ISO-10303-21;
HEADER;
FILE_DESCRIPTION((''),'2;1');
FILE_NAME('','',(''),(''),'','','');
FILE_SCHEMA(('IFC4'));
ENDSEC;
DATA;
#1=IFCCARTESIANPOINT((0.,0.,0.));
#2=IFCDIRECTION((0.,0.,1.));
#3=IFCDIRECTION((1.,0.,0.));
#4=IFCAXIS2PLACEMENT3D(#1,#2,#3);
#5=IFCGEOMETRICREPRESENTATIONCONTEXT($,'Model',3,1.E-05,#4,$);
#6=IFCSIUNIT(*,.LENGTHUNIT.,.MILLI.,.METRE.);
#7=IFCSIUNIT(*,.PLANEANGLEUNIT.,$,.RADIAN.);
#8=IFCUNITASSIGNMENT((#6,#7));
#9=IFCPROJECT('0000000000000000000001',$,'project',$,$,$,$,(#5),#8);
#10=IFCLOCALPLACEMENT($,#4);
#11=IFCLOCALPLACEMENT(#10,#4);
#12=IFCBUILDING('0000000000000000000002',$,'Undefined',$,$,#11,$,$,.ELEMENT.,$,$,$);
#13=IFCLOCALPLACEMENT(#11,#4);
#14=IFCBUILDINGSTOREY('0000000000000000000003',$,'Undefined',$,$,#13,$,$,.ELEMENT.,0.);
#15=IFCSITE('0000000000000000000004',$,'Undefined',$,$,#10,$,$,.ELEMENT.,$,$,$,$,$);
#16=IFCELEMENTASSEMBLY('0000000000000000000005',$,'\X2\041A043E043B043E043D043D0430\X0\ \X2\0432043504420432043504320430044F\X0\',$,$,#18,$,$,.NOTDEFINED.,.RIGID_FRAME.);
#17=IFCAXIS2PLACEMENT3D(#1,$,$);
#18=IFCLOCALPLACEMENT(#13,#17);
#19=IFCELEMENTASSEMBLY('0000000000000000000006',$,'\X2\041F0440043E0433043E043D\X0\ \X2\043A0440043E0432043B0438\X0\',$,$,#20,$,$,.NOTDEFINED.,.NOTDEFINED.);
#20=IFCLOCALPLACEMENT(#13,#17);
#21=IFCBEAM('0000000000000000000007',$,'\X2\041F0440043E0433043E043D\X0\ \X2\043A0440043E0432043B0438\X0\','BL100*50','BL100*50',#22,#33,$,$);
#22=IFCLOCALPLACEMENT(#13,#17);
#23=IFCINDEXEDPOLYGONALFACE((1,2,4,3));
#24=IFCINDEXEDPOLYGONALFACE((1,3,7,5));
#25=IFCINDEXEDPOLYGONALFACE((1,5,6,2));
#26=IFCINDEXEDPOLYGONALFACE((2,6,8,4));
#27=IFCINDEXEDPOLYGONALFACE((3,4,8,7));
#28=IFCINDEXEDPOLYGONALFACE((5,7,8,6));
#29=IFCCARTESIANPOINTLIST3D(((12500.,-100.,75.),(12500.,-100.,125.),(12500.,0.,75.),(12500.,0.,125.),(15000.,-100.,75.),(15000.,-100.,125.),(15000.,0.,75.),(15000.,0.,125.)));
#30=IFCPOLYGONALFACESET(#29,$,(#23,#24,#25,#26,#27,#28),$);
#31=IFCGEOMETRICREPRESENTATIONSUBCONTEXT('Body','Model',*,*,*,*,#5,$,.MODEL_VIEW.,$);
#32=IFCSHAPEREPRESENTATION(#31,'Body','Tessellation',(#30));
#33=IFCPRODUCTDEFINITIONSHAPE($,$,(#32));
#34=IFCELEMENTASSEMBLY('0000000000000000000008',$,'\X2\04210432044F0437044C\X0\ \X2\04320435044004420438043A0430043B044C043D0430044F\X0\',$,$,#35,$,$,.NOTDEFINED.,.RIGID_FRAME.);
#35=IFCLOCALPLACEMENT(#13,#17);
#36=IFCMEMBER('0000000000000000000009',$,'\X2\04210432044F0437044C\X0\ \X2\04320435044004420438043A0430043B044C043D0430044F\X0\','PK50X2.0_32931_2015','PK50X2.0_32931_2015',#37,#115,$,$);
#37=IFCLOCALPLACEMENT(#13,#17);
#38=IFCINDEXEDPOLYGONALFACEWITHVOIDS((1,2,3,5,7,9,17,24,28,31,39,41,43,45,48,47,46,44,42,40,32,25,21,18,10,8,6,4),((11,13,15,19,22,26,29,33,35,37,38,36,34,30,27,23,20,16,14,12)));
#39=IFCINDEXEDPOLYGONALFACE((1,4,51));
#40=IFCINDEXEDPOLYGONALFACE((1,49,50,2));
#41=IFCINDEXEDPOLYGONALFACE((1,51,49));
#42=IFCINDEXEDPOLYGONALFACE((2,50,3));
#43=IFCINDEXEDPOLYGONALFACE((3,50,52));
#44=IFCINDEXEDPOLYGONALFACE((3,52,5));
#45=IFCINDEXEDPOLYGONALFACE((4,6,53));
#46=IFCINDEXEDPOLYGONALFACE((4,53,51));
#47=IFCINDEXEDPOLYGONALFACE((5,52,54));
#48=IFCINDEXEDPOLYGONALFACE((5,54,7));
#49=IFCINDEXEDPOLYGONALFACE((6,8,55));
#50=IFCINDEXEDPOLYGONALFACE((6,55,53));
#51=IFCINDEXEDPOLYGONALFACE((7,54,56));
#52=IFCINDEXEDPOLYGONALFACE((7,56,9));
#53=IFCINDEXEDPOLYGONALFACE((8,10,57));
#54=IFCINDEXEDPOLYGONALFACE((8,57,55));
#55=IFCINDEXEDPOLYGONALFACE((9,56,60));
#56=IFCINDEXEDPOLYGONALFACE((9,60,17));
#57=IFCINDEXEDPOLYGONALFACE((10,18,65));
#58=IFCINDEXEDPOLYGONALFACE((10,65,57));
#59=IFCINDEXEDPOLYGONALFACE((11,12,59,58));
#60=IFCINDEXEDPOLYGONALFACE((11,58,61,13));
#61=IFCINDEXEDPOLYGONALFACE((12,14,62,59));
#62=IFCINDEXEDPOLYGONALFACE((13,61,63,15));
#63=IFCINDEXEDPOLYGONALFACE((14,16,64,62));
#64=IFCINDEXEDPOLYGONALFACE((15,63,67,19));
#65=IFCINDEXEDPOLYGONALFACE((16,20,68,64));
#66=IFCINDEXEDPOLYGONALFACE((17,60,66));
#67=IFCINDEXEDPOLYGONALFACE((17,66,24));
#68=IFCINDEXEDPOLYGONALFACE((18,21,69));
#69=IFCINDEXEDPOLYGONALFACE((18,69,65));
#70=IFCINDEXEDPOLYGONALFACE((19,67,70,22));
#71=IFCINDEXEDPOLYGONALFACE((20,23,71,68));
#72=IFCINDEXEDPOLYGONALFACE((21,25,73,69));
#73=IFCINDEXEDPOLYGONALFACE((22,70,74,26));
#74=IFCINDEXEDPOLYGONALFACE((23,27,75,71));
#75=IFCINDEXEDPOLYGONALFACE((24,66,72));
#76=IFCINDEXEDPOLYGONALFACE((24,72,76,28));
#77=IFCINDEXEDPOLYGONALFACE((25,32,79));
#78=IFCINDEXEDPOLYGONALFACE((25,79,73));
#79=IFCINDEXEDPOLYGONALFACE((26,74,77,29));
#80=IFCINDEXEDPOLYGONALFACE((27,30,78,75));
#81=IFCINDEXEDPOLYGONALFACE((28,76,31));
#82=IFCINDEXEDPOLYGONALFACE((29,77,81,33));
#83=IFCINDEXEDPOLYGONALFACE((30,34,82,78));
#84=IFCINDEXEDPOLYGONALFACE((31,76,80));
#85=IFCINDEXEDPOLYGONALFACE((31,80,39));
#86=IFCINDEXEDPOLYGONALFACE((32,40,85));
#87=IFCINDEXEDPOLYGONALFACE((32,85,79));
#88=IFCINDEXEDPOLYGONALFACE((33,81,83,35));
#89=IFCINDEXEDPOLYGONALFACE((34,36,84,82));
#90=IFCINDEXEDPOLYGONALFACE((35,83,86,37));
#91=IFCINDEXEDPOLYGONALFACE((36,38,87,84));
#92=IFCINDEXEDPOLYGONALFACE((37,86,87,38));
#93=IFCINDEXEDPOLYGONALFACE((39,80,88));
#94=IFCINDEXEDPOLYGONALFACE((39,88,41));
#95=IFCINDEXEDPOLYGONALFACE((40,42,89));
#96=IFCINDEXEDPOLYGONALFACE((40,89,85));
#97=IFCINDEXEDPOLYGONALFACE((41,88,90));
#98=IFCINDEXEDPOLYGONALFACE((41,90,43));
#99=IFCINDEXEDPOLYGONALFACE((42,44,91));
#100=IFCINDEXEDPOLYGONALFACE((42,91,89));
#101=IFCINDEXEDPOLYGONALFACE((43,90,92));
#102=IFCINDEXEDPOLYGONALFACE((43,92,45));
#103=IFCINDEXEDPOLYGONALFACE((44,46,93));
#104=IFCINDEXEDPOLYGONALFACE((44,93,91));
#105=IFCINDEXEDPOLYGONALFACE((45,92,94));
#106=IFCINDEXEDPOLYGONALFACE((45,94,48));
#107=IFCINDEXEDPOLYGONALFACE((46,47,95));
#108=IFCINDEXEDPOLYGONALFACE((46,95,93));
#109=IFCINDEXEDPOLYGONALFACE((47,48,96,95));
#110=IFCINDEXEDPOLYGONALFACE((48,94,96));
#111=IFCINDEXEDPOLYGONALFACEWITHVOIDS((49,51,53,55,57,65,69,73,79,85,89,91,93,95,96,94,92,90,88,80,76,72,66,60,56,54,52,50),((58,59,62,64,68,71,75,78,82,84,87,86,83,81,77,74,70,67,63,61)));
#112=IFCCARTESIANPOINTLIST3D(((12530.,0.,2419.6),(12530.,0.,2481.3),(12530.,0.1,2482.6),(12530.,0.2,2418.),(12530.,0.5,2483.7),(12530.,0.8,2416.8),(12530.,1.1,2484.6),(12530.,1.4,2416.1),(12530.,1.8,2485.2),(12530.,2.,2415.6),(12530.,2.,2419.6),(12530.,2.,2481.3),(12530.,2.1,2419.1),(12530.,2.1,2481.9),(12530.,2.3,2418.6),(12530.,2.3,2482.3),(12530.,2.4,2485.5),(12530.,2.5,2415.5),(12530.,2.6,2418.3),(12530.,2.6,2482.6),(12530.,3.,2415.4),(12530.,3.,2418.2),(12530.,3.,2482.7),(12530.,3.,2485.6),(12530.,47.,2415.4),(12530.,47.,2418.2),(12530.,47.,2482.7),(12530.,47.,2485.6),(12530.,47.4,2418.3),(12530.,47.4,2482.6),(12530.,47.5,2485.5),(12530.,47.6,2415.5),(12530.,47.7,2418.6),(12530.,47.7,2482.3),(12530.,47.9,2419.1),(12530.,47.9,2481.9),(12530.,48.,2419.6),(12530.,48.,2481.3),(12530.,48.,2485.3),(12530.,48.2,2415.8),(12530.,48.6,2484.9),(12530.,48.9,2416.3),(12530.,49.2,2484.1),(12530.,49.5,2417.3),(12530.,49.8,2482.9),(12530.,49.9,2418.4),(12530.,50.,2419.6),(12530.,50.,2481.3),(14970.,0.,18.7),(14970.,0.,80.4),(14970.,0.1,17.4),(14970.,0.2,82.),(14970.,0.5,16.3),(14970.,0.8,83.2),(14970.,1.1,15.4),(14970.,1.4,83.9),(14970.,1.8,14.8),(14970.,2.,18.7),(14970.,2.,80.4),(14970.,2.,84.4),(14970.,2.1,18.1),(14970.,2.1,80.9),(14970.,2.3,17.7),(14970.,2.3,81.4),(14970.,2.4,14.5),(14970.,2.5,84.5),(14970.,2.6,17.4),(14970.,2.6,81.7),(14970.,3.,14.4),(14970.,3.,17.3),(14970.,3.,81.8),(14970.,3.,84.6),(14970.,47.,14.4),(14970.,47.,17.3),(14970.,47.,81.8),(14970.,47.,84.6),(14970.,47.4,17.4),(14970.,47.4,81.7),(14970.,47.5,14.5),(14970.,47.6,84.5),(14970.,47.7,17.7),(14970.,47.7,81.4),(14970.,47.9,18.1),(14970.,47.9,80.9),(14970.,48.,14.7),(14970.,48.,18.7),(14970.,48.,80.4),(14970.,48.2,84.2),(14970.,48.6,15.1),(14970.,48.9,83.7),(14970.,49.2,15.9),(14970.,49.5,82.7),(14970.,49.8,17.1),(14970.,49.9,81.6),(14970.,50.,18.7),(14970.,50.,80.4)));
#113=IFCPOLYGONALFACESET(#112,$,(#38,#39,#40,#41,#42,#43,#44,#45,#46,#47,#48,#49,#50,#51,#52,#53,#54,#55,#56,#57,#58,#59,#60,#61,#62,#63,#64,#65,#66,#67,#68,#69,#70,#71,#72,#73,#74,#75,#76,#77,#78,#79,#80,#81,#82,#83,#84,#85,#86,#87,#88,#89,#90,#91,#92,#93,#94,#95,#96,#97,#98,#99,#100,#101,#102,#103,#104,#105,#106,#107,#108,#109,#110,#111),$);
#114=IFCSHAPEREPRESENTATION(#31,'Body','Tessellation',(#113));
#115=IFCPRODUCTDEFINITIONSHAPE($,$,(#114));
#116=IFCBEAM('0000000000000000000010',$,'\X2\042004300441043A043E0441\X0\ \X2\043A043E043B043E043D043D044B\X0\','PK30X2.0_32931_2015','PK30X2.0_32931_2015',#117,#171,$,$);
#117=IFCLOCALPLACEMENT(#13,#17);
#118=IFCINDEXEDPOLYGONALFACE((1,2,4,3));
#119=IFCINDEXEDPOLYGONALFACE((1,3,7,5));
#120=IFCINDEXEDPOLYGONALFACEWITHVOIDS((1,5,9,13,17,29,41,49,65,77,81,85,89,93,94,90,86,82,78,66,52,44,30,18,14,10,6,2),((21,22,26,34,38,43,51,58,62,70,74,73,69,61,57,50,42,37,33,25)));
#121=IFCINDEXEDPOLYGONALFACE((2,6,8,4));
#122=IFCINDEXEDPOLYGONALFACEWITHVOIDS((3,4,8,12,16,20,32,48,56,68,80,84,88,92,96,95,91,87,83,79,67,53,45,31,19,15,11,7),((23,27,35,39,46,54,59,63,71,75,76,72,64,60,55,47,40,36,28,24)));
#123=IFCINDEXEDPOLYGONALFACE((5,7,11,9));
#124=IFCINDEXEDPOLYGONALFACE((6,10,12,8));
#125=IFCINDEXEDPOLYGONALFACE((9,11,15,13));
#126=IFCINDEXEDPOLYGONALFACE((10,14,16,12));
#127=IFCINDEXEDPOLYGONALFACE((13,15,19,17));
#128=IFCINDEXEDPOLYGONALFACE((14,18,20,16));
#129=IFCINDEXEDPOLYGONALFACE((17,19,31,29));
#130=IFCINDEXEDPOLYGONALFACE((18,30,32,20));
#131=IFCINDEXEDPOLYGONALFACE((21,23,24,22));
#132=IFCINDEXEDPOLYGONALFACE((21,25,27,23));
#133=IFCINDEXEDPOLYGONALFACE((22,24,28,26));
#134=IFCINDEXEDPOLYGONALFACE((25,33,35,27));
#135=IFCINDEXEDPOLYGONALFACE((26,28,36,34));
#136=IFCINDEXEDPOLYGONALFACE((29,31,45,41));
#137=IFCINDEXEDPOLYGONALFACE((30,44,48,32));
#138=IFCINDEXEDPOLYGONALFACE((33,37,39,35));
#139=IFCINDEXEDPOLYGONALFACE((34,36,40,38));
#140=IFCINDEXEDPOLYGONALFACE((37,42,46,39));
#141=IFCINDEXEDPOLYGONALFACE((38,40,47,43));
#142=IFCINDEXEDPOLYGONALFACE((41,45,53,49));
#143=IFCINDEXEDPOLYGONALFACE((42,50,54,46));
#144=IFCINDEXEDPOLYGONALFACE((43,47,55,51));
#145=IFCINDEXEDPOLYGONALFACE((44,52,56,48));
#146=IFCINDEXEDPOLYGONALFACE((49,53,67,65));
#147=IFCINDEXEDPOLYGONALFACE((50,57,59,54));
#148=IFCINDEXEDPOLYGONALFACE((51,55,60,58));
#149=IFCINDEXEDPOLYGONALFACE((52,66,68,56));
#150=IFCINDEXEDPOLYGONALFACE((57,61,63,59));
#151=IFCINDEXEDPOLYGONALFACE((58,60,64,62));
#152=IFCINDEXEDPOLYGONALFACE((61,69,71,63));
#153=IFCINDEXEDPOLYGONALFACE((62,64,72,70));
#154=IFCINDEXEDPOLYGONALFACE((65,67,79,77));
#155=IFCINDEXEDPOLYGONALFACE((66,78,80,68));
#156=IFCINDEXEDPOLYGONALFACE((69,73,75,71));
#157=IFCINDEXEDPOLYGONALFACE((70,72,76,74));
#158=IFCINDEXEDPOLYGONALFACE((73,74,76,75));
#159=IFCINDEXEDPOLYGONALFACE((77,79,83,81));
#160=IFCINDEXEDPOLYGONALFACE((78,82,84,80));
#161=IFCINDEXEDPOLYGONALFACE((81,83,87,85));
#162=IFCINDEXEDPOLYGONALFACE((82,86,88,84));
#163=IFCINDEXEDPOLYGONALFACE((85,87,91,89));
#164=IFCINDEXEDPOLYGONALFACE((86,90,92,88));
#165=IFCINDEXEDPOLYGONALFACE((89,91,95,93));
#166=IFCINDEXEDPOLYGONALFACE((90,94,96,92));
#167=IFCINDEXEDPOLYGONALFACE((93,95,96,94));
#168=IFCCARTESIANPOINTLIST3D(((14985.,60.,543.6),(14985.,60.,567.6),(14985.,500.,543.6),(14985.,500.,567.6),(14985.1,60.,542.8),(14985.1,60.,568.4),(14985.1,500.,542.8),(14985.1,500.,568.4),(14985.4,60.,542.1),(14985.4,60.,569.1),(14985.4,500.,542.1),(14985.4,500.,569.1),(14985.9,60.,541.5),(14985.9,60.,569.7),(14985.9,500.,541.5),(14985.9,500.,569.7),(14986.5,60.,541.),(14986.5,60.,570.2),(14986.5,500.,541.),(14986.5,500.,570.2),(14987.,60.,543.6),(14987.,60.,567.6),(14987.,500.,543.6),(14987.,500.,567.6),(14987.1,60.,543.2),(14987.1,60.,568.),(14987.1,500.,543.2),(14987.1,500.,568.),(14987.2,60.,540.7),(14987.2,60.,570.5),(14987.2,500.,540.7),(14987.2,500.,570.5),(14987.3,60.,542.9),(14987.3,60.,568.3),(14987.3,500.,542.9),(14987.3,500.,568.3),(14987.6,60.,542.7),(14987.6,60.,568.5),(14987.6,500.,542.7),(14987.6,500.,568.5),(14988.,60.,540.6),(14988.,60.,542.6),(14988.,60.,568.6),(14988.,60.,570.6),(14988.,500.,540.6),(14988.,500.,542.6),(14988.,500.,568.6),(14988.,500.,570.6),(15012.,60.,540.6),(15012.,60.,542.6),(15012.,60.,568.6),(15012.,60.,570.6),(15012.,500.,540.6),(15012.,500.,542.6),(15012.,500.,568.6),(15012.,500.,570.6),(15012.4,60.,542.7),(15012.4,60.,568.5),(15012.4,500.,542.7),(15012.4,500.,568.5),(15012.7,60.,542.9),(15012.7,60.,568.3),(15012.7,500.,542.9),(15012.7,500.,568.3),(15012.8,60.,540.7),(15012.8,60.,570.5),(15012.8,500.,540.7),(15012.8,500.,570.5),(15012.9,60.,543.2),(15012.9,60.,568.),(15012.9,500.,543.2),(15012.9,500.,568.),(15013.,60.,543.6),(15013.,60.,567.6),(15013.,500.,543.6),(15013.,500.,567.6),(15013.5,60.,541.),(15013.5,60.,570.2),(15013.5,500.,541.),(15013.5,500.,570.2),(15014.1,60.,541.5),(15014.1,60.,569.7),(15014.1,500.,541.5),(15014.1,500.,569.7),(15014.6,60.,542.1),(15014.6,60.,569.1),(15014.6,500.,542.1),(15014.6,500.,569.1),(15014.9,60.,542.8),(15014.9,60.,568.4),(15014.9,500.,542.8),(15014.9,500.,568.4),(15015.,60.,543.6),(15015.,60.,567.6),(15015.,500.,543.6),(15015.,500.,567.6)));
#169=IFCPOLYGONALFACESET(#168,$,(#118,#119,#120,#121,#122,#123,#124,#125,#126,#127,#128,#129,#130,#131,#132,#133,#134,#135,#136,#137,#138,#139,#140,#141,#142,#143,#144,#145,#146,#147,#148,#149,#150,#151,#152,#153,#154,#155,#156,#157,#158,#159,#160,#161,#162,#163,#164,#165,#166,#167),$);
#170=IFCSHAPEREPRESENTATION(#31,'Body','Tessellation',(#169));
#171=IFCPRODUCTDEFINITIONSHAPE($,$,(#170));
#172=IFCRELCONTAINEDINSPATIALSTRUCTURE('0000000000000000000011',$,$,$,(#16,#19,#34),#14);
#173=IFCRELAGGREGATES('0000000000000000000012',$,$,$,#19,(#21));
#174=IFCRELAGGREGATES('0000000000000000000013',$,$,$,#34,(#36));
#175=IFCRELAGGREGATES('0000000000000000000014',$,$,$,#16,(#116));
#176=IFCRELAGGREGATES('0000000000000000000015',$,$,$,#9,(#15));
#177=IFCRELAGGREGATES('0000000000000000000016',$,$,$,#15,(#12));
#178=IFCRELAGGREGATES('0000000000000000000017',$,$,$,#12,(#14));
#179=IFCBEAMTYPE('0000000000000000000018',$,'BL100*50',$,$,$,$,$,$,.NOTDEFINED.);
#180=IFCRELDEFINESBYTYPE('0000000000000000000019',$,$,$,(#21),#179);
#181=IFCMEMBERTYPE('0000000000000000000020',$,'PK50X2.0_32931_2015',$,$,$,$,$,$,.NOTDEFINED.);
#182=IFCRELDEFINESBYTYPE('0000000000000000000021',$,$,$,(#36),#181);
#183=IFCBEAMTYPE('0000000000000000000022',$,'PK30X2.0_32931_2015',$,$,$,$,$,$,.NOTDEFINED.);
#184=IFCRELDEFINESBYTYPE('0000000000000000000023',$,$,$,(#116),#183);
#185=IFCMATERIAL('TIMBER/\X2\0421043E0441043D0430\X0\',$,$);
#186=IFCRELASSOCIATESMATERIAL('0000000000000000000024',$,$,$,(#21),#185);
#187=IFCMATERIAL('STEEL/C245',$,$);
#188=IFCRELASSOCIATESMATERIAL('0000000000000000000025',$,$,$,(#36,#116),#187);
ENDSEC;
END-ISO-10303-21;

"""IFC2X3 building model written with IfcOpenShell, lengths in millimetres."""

from ifc_helpers import new_model, si_unit, frame, origin_with_axes, origin_2d_with_axis, place, context, subcontext, project, spatial, rectangle, hollow_rectangle, extrude, clip, halfspace, material, type_object, element, aggregate, save


model = new_model("IFC2X3")

# Units and contexts
model_context = context("Model", 3, precision=1e-05, world=origin_with_axes())
body_context = subcontext(model_context, "Body", "Model", "MODEL_VIEW")
ifc_project = project(units=[si_unit("LENGTHUNIT", "METRE", prefix="MILLI"), si_unit("PLANEANGLEUNIT", "RADIAN")], contexts=[model_context])

# Site, building, storey
site_placement = place(None, origin_with_axes())
site = spatial("IfcSite", under=ifc_project, at=site_placement, Name="Undefined", CompositionType="ELEMENT")
building_placement = place(site_placement, origin_with_axes())
building = spatial("IfcBuilding", under=site, at=building_placement, Name="Undefined", CompositionType="ELEMENT")
storey_placement = place(building_placement, origin_with_axes())
storey = spatial("IfcBuildingStorey", under=building, at=storey_placement, Name="Undefined", CompositionType="ELEMENT", Elevation=0.0)

# Element assembly
assembly_1_placement = place(storey_placement, origin_with_axes())
assembly_1 = element("IfcElementAssembly", 1, at=assembly_1_placement, inside=storey, Name="Колонна ветвевая", AssemblyPlace="NOTDEFINED", PredefinedType="RIGID_FRAME")
ifc_material_1 = material(Name="STEEL/C245")

# Element assembly, beam
ifc_material_2 = material(Name="TIMBER/Сосна")
beam_type_1 = type_object("IfcBeamType", Name="BL100*50", PredefinedType="NOTDEFINED")
assembly_2_placement = place(storey_placement, origin_with_axes())
assembly_2 = element("IfcElementAssembly", 2, at=assembly_2_placement, inside=storey, Name="Прогон кровли", AssemblyPlace="NOTDEFINED", PredefinedType="NOTDEFINED")
beam_1_placement = place(assembly_2_placement, frame((12500.0, -50.0, 100.0), z_axis=(0.0, -1.0, 0.0), x_axis=(1.0, 0.0, 0.0)))
beam_1 = element("IfcBeam", 3, at=beam_1_placement, type_object=beam_type_1, material=ifc_material_2, Name="Прогон кровли", Description="BL100*50", ObjectType="BL100*50", context=body_context, shape_type="SweptSolid", body=[
    extrude(rectangle(XDim=50.0, YDim=100.0, at=origin_2d_with_axis()), frame((2500.0, 0.0, 0.0), z_axis=(-1.0, 0.0, 0.0), x_axis=(0.0, -1.0, 0.0)), (0.0, 0.0, 1.0), 2500.0),
])
aggregate(assembly_2, [beam_1])

# Element assembly, member
assembly_3_placement = place(storey_placement, origin_with_axes())
assembly_3 = element("IfcElementAssembly", 4, at=assembly_3_placement, inside=storey, Name="Связь вертикальная", AssemblyPlace="NOTDEFINED", PredefinedType="RIGID_FRAME")
member_type_1 = type_object("IfcMemberType", Name="PK50X2.0_32931_2015", PredefinedType="NOTDEFINED")
member_1_placement = place(assembly_3_placement, frame((15000.0, 25.0, 20.0), z_axis=(0.701381, 0.0, 0.712786), x_axis=(-0.712786, 0.0, 0.701381)))
member_1 = element("IfcMember", 5, at=member_1_placement, type_object=member_type_1, material=ifc_material_1, Name="Связь вертикальная", Description="PK50X2.0_32931_2015", ObjectType="PK50X2.0_32931_2015", context=body_context, shape_type="Clipping", body=[
    clip(clip(extrude(hollow_rectangle(XDim=50.0, YDim=50.0, WallThickness=2.0, InnerFilletRadius=1.0, OuterFilletRadius=3.0, at=origin_2d_with_axis()), frame((3515.0, 0.0, 0.0), z_axis=(-1.0, 0.0, 0.0), x_axis=(0.0, -1.0, 0.0)), (0.0, 0.0, 1.0), 3522.6), halfspace(frame((3446.9, 25.0, -18.6), z_axis=(-0.712786, 0.0, 0.701381), x_axis=(-0.701381, 0.0, -0.712786)), True)), halfspace(frame((87.1, 25.0, 45.7), z_axis=(0.712786, 0.0, -0.701381), x_axis=(0.701381, 0.0, 0.712786)), True)),
])
aggregate(assembly_3, [member_1])

# Beam
beam_type_2 = type_object("IfcBeamType", Name="PK30X2.0_32931_2015", PredefinedType="NOTDEFINED")
beam_2_placement = place(assembly_1_placement, frame((15000.0, 500.0, 555.6), z_axis=(0.0, 0.0, 1.0), x_axis=(0.0, -1.0, 0.0)))
beam_2 = element("IfcBeam", 6, at=beam_2_placement, type_object=beam_type_2, material=ifc_material_1, Name="Раскос колонны", Description="PK30X2.0_32931_2015", ObjectType="PK30X2.0_32931_2015", context=body_context, shape_type="SweptSolid", body=[
    extrude(hollow_rectangle(XDim=30.0, YDim=30.0, WallThickness=2.0, InnerFilletRadius=1.0, OuterFilletRadius=3.0, at=origin_2d_with_axis()), frame((440.0, 0.0, 0.0), z_axis=(-1.0, 0.0, 0.0), x_axis=(0.0, -1.0, 0.0)), (0.0, 0.0, 1.0), 440.0),
])

aggregate(assembly_1, [beam_2])

save(model, "model.ifc")
